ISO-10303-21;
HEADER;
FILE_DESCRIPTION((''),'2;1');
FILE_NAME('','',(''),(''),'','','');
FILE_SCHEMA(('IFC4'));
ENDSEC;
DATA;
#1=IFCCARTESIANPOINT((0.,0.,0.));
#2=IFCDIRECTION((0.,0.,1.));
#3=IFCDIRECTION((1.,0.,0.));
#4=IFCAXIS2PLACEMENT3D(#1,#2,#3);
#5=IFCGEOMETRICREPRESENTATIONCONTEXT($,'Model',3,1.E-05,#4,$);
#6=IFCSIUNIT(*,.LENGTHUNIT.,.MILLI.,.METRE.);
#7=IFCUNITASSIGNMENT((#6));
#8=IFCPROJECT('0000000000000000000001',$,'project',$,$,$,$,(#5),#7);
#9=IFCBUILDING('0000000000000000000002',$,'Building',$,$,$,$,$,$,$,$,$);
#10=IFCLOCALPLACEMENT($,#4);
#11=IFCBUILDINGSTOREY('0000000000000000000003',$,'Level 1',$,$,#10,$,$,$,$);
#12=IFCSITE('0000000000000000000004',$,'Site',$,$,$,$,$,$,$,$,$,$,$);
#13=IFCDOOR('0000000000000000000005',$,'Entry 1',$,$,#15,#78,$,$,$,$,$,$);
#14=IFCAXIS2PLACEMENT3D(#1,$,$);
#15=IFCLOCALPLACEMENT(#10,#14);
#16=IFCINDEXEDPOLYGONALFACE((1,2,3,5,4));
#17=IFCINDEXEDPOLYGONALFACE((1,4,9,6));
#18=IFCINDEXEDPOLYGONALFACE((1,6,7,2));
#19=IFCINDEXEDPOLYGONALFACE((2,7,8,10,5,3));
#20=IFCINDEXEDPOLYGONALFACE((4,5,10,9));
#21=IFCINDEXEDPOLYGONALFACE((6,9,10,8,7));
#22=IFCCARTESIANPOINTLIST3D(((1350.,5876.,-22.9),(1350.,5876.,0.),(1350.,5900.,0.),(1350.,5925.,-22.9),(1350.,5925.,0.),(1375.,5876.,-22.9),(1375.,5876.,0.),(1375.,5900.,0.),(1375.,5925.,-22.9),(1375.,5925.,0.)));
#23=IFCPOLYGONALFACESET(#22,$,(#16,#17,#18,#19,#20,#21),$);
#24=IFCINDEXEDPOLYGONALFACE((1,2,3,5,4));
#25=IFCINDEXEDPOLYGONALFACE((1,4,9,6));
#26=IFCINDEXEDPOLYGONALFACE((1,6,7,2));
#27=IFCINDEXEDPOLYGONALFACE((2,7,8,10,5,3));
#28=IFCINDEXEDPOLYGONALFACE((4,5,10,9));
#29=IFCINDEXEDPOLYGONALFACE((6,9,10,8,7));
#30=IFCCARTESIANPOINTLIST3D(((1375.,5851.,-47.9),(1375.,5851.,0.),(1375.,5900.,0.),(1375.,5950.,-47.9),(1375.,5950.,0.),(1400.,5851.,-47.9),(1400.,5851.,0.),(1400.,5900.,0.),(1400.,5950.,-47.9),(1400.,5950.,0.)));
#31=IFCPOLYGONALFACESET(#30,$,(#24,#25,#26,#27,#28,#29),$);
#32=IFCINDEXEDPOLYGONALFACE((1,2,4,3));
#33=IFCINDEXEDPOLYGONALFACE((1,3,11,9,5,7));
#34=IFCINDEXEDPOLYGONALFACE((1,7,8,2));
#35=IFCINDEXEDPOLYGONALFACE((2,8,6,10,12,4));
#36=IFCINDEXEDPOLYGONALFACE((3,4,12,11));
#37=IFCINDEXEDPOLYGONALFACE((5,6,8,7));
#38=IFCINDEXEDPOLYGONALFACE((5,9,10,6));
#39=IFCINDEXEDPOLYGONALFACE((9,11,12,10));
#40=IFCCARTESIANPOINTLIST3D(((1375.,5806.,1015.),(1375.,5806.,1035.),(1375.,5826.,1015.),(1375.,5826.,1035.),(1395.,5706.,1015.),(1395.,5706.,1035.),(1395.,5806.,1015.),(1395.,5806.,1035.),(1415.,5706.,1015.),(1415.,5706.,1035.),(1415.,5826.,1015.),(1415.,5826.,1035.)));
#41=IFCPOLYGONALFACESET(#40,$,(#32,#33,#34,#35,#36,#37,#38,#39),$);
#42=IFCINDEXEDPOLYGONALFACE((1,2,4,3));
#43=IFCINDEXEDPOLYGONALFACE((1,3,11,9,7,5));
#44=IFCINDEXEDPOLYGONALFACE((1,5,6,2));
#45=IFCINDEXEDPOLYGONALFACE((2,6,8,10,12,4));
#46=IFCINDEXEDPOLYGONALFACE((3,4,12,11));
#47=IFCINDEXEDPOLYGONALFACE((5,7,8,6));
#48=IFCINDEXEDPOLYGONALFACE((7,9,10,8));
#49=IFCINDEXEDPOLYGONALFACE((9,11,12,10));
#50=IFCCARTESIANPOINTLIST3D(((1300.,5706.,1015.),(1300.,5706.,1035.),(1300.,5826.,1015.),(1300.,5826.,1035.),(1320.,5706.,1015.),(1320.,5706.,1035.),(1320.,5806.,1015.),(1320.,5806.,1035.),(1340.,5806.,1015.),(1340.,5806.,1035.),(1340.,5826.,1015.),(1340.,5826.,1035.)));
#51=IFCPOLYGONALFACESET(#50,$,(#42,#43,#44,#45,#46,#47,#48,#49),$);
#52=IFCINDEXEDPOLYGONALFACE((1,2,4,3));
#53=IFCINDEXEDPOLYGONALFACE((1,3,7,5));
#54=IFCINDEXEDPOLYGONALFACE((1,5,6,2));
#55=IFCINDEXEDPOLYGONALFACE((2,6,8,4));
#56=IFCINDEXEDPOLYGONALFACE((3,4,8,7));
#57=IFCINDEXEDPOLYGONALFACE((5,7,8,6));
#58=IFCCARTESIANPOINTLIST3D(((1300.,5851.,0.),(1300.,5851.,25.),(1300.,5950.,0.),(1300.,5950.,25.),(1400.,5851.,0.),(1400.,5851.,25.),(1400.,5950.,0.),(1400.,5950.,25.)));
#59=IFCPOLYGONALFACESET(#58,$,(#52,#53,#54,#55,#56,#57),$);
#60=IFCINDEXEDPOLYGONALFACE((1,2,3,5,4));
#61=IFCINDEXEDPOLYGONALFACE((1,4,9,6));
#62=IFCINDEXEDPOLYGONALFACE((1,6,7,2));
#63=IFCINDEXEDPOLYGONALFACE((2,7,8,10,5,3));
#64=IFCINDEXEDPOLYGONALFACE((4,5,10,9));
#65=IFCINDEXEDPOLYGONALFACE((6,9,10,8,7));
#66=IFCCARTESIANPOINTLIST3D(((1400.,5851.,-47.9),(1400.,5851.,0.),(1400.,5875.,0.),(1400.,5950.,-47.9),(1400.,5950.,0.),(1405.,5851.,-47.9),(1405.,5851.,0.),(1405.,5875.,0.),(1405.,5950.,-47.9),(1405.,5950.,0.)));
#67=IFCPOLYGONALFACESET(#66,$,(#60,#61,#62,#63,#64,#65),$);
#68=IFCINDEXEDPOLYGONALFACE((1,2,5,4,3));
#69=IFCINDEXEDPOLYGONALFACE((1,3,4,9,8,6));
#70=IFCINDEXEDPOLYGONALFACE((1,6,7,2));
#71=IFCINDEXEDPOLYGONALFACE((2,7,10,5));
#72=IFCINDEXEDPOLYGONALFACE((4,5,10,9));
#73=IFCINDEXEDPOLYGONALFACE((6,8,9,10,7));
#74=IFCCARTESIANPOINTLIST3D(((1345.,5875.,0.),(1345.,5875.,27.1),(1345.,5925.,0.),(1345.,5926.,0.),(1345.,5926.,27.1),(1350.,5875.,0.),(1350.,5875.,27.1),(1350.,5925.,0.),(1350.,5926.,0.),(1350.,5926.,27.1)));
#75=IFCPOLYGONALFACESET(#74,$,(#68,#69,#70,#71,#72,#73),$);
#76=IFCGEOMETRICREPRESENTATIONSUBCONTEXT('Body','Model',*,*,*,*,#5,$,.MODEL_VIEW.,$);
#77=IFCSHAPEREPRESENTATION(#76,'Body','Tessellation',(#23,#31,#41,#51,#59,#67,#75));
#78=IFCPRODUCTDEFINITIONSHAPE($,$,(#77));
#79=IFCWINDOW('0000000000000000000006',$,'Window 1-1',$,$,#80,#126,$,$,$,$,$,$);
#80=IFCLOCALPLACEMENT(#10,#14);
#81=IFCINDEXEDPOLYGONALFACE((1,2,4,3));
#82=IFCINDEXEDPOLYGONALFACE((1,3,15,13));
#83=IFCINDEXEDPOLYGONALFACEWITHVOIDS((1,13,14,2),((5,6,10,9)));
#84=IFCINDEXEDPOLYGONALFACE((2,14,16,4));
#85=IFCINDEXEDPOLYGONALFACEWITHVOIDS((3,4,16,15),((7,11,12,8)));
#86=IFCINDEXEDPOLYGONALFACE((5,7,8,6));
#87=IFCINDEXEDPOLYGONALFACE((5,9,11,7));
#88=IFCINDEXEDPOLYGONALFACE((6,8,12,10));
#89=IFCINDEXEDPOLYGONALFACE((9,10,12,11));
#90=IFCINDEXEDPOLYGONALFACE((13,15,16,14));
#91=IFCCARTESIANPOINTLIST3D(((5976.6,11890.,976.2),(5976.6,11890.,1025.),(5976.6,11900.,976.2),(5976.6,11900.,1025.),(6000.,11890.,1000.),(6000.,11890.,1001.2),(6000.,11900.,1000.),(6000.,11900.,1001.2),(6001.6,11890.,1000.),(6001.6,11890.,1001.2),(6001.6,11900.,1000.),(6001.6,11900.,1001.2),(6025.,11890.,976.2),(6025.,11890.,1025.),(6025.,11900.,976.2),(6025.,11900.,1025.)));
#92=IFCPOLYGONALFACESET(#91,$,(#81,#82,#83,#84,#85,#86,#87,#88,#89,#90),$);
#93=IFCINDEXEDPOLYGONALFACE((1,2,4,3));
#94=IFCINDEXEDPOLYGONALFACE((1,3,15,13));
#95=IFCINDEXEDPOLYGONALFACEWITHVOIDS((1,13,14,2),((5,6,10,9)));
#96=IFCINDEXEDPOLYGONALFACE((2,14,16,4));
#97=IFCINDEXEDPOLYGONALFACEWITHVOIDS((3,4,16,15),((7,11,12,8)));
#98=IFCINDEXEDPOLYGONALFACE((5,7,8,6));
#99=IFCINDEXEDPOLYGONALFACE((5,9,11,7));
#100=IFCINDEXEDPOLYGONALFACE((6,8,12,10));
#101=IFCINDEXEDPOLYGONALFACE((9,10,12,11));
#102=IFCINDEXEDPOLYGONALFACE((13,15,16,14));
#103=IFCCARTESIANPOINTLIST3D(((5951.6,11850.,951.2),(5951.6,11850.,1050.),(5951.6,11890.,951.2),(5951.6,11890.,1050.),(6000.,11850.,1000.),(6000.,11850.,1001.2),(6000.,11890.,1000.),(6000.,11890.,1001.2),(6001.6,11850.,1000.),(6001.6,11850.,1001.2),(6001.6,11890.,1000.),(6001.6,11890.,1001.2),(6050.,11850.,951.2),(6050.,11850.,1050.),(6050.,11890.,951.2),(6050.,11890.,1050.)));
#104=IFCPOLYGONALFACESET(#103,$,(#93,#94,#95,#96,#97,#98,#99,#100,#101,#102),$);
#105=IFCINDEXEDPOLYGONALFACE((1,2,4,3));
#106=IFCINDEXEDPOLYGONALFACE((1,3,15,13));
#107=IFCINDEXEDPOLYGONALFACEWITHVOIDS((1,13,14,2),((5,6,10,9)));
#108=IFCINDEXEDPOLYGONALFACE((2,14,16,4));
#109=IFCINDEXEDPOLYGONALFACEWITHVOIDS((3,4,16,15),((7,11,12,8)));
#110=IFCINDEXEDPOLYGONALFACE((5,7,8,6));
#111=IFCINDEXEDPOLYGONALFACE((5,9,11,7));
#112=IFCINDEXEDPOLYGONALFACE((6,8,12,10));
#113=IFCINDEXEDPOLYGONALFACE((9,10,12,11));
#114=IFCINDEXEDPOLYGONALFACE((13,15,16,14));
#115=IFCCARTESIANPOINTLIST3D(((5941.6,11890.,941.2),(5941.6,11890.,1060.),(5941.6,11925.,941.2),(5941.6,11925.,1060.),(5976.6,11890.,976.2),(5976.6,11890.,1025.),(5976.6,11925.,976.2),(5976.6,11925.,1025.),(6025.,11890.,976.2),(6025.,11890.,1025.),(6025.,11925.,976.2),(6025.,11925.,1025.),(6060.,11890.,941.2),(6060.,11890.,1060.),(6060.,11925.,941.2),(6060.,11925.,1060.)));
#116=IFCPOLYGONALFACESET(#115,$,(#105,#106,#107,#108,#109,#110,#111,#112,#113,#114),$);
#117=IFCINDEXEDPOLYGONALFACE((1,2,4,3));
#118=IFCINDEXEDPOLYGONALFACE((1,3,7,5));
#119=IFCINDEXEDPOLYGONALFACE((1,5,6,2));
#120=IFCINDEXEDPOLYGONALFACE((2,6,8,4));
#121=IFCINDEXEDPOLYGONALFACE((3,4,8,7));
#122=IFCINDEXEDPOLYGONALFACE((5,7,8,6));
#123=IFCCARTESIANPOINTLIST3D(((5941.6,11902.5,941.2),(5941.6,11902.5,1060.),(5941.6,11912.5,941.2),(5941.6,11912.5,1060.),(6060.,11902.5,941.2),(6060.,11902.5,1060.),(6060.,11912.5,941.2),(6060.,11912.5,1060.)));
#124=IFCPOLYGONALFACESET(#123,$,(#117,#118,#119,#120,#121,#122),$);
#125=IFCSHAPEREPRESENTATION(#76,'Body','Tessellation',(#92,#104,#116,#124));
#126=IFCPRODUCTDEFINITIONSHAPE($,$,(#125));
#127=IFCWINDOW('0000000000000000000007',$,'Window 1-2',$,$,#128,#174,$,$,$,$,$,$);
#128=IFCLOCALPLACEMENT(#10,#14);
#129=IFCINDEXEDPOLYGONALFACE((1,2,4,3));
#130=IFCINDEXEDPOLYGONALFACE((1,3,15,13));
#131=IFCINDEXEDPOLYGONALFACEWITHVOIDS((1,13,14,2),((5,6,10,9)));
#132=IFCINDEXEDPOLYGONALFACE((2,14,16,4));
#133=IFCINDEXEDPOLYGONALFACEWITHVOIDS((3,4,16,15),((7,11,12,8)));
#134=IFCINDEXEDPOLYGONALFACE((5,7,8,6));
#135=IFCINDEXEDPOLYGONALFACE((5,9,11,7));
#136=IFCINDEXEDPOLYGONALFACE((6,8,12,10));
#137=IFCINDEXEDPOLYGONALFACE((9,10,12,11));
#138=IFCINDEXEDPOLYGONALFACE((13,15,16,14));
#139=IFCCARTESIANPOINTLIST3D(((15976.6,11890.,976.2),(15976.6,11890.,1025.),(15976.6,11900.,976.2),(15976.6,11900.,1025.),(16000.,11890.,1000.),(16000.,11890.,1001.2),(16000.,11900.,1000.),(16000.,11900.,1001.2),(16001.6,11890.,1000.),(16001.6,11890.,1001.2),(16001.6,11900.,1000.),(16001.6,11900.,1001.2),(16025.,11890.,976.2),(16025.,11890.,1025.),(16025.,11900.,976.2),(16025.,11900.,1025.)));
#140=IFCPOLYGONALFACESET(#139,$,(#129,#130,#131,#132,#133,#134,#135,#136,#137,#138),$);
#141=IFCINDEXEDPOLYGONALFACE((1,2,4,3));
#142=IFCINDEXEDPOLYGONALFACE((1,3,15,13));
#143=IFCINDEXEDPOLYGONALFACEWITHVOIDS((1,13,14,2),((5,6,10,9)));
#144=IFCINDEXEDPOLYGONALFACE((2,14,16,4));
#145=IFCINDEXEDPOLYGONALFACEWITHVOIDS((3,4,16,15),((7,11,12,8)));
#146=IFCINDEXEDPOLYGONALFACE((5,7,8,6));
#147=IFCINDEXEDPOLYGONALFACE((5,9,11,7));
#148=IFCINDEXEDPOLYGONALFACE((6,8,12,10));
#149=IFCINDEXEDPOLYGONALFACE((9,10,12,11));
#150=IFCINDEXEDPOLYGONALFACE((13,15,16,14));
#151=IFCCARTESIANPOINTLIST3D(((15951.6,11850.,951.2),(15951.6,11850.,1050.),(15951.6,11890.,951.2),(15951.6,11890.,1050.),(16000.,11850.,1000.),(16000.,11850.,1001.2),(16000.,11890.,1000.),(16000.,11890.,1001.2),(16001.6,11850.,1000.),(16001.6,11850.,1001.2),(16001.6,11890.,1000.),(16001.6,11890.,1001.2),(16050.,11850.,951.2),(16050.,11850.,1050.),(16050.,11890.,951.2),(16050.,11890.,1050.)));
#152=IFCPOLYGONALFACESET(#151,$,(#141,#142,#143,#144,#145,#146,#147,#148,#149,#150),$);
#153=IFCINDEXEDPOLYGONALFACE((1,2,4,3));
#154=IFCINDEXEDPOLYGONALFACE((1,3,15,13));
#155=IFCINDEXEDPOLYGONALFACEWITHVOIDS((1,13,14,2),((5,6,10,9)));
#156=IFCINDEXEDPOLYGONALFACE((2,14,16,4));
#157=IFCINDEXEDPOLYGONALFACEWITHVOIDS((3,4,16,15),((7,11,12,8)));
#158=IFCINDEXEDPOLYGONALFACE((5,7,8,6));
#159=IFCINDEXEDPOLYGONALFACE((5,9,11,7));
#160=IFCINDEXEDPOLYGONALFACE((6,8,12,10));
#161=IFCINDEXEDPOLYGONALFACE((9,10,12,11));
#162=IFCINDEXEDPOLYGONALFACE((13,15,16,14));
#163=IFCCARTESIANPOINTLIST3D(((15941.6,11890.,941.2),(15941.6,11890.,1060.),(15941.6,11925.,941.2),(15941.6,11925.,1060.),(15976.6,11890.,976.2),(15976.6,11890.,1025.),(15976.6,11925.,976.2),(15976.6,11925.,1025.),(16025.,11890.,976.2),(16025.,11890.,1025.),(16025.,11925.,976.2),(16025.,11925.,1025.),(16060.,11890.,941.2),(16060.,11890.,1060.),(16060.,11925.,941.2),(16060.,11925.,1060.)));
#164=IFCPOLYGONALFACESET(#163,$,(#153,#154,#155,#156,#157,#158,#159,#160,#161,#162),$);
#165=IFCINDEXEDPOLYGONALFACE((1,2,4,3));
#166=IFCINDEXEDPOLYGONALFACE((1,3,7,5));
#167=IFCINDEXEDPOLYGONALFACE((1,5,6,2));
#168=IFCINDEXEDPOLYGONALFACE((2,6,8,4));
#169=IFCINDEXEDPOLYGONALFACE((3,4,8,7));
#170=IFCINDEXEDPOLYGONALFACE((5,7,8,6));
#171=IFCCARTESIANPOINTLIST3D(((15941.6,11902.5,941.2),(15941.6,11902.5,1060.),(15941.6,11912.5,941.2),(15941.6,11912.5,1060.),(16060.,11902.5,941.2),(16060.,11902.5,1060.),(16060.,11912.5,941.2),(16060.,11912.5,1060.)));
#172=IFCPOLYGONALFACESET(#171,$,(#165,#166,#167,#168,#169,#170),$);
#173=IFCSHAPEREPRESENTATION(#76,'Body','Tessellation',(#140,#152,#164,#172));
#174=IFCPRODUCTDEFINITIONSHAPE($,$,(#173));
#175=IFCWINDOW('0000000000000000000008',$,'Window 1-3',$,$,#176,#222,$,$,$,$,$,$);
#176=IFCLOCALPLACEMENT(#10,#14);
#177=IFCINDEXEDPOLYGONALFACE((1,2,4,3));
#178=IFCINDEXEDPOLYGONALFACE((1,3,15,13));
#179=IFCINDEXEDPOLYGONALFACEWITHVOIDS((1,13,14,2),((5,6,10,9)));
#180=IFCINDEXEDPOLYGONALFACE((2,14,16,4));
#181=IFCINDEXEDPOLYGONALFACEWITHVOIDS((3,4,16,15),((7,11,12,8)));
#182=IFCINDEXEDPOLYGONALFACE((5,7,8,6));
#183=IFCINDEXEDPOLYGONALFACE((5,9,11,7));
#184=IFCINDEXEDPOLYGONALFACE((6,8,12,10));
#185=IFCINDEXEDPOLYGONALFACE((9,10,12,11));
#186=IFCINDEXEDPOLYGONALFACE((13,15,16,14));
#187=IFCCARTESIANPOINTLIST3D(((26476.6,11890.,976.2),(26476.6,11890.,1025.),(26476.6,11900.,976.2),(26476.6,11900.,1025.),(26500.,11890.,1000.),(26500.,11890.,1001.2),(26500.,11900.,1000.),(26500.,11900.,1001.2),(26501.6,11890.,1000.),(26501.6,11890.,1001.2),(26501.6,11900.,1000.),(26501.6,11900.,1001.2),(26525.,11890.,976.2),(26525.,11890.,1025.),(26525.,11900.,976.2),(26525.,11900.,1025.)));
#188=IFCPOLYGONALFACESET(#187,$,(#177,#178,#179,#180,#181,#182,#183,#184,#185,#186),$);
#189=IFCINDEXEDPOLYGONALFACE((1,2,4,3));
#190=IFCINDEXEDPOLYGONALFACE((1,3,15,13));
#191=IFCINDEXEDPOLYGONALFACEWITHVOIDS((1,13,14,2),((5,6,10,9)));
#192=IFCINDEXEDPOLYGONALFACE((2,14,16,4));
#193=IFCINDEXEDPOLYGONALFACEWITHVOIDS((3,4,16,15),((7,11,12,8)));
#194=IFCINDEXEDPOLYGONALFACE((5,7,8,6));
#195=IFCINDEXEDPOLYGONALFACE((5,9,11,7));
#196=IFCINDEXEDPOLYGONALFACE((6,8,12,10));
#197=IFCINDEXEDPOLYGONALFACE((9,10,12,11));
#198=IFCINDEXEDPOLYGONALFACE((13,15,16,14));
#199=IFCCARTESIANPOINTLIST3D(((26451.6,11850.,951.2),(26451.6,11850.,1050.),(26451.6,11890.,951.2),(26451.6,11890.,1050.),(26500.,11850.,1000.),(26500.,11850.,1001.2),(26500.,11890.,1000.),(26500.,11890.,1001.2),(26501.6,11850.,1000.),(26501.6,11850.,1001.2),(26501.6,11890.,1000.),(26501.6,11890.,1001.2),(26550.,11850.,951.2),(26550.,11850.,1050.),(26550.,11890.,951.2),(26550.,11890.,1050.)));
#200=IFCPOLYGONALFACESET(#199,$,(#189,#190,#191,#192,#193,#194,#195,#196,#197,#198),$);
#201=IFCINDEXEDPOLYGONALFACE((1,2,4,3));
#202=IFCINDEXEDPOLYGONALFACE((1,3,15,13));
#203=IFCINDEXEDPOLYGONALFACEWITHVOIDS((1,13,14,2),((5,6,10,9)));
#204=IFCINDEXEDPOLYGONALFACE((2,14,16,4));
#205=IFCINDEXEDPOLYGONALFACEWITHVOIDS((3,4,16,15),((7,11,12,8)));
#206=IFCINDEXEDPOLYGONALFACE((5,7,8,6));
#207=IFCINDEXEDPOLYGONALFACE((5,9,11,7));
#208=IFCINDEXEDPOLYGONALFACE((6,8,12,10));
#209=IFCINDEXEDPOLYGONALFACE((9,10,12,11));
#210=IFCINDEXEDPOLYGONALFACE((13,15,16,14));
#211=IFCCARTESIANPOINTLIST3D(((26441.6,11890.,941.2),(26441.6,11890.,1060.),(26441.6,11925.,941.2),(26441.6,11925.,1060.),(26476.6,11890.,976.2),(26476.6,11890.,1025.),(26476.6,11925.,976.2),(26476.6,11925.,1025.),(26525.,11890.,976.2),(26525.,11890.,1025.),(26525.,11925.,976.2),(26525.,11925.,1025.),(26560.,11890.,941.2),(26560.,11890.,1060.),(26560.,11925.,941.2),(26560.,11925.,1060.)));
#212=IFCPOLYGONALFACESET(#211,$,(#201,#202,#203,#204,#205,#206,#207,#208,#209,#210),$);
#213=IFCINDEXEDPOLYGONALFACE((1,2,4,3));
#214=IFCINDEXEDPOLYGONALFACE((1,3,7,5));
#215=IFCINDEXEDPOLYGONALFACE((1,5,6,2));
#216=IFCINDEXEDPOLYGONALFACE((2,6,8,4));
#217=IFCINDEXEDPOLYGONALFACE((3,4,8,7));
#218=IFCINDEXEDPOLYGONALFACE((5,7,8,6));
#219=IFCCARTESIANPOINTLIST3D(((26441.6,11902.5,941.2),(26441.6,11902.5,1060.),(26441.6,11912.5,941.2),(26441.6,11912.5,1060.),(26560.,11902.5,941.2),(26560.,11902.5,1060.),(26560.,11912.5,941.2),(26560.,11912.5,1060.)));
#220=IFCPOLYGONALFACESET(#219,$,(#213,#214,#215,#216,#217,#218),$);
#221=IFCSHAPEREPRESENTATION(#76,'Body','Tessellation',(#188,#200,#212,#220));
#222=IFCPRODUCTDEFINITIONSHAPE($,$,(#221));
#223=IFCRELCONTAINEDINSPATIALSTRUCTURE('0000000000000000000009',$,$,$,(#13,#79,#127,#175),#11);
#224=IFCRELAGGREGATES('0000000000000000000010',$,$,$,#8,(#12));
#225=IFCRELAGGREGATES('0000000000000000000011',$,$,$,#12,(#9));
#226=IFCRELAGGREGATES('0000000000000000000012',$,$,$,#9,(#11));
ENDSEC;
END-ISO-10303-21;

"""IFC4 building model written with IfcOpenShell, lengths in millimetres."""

from ifc_helpers import new_model, si_unit, frame, origin_with_axes, place, context, subcontext, project, spatial, line, indexed_curve, outline, extrude, element, save


model = new_model("IFC4")

# Units and contexts
model_context = context("Model", 3, precision=1e-05, world=origin_with_axes())
body_context = subcontext(model_context, "Body", "Model", "MODEL_VIEW")
ifc_project = project(units=[si_unit("LENGTHUNIT", "METRE", prefix="MILLI")], contexts=[model_context])

# Site, building, storey
site = spatial("IfcSite", under=ifc_project, Name="Site")
building = spatial("IfcBuilding", under=site, Name="Building")
storey_placement = place(None, origin_with_axes())
storey = spatial("IfcBuildingStorey", under=building, at=storey_placement, Name="Level 1")

# Door
door_1_placement = place(storey_placement, frame((1400.0, 5900.0, 0.0), z_axis=(0.0, 0.0, 1.0), x_axis=(0.0, 1.0, 0.0)))
element("IfcDoor", 1, at=door_1_placement, inside=storey, Name="Entry 1", context=body_context, shape_type="SweptSolid", body=[
    extrude(outline(indexed_curve([(0.0, 0.0), (0.0, 2.1), (1.0, 2.1), (1.0, 0.0), (-24.0, 0.0), (-24.0, -22.9), (25.0, -22.9), (25.0, 0.0)], segments=[line(1, 2, 3, 4, 5, 6, 7, 8, 1)])), frame((0.0, 25.0, 0.0), z_axis=(0.0, -1.0, 0.0), x_axis=(1.0, 0.0, 0.0)), (0.0, 0.0, -1.0), 25.0),
    extrude(outline(indexed_curve([(0.0, 0.0), (0.0, 2.1), (1.0, 2.1), (1.0, 0.0), (-49.0, 0.0), (-49.0, -47.9), (50.0, -47.9), (50.0, 0.0)], segments=[line(1, 2, 3, 4, 5, 6, 7, 8, 1)])), frame((0.0, 0.0, 0.0), z_axis=(0.0, -1.0, 0.0), x_axis=(1.0, 0.0, 0.0)), (0.0, 0.0, -1.0), 25.0),
    extrude(outline(indexed_curve([(0.0, 0.0), (-49.0, 0.0), (-49.0, 35.0), (0.0, 35.0)], segments=[line(1, 2, 3, 4, 1)])), frame((25.0, 25.0, 25.0), z_axis=(0.0, 0.0, 1.0), x_axis=(1.0, 0.0, 0.0)), (0.0, 0.0, 1.0), -47.9),
    extrude(outline(indexed_curve([(0.0, 0.0), (0.0, -40.0), (-120.0, -40.0), (-120.0, -20.0), (-20.0, -20.0), (-20.0, 0.0)], segments=[line(1, 2, 3, 4, 5, 6, 1)])), frame((-74.0, 25.0, 1015.0), z_axis=(0.0, 0.0, 1.0), x_axis=(1.0, 0.0, 0.0)), (0.0, 0.0, 1.0), 20.0),
    extrude(outline(indexed_curve([(0.0, 0.0), (0.0, 40.0), (-120.0, 40.0), (-120.0, 20.0), (-20.0, 20.0), (-20.0, 0.0)], segments=[line(1, 2, 3, 4, 5, 6, 1)])), frame((-74.0, 60.0, 1015.0), z_axis=(0.0, 0.0, 1.0), x_axis=(1.0, 0.0, 0.0)), (0.0, 0.0, 1.0), 20.0),
    extrude(outline(indexed_curve([(0.0, 0.0), (-99.0, 0.0), (-99.0, 100.0), (0.0, 100.0)], segments=[line(1, 2, 3, 4, 1)])), frame((50.0, 0.0, 0.0), z_axis=(0.0, 0.0, 1.0), x_axis=(1.0, 0.0, 0.0)), (0.0, 0.0, 1.0), 25.0),
    extrude(outline(indexed_curve([(0.0, 0.0), (0.0, 27.1), (51.0, 27.1), (51.0, 0.0), (-24.0, 0.0), (-24.0, -47.9), (75.0, -47.9), (75.0, 0.0)], segments=[line(1, 2, 3, 4, 5, 6, 7, 8, 1)])), frame((-25.0, -5.0, 0.0), z_axis=(0.0, -1.0, 0.0), x_axis=(1.0, 0.0, 0.0)), (0.0, 0.0, -1.0), 5.0),
    extrude(outline(indexed_curve([(0.0, 0.0), (0.0, 27.1), (51.0, 27.1), (51.0, 0.0), (1.0, 0.0), (1.0, -22.9), (50.0, -22.9), (50.0, 0.0)], segments=[line(1, 2, 3, 4, 5, 6, 7, 8, 1)])), frame((-25.0, 50.0, 0.0), z_axis=(0.0, -1.0, 0.0), x_axis=(1.0, 0.0, 0.0)), (0.0, 0.0, -1.0), 5.0),
])

# Windows
for number, where, z_axis, x_axis, name in (
    (2, (6000.0, 11800.0, 1000.0), (0.0, 0.0, 1.0), (1.0, 0.0, 0.0), "Window 1-1"),
    (3, (16000.0, 11800.0, 1000.0), (0.0, 0.0, 1.0), (1.0, 0.0, 0.0), "Window 1-2"),
    (4, (26500.0, 11800.0, 1000.0), (0.0, 0.0, 1.0), (1.0, 0.0, 0.0), "Window 1-3"),
):
    element("IfcWindow", number, at=place(storey_placement, frame(where, z_axis=z_axis, x_axis=x_axis)), inside=storey, Name=name, context=body_context, shape_type="SweptSolid", body=[
        extrude(outline(indexed_curve([(0.0, 0.0), (1.6, 0.0), (1.6, 1.2), (0.0, 1.2)], segments=[line(1, 2, 3, 4, 1)]), holes=[indexed_curve([(25.0, 25.0), (-23.4, 25.0), (-23.4, -23.8), (25.0, -23.8)], segments=[line(1, 2, 3, 4, 1)])]), frame((0.0, 90.0, 0.0), z_axis=(0.0, -1.0, 0.0), x_axis=(1.0, 0.0, 0.0)), (0.0, 0.0, -1.0), 10.0),
        extrude(outline(indexed_curve([(0.0, 0.0), (1.6, 0.0), (1.6, 1.2), (0.0, 1.2)], segments=[line(1, 2, 3, 4, 1)]), holes=[indexed_curve([(50.0, 50.0), (-48.4, 50.0), (-48.4, -48.8), (50.0, -48.8)], segments=[line(1, 2, 3, 4, 1)])]), frame((0.0, 50.0, 0.0), z_axis=(0.0, -1.0, 0.0), x_axis=(1.0, 0.0, 0.0)), (0.0, 0.0, -1.0), 40.0),
        extrude(outline(indexed_curve([(0.0, 0.0), (-48.4, 0.0), (-48.4, -48.8), (0.0, -48.8)], segments=[line(1, 2, 3, 4, 1)]), holes=[indexed_curve([(35.0, 35.0), (-83.4, 35.0), (-83.4, -83.8), (35.0, -83.8)], segments=[line(1, 2, 3, 4, 1)])]), frame((25.0, 90.0, 25.0), z_axis=(0.0, -1.0, 0.0), x_axis=(1.0, 0.0, 0.0)), (0.0, 0.0, -1.0), 35.0),
        extrude(outline(indexed_curve([(35.0, 35.0), (-83.4, 35.0), (-83.4, -83.8), (35.0, -83.8)], segments=[line(1, 2, 3, 4, 1)])), frame((25.0, 102.5, 25.0), z_axis=(0.0, -1.0, 0.0), x_axis=(1.0, 0.0, 0.0)), (0.0, 0.0, -1.0), 10.0),
    ])

save(model, "model.ifc")
